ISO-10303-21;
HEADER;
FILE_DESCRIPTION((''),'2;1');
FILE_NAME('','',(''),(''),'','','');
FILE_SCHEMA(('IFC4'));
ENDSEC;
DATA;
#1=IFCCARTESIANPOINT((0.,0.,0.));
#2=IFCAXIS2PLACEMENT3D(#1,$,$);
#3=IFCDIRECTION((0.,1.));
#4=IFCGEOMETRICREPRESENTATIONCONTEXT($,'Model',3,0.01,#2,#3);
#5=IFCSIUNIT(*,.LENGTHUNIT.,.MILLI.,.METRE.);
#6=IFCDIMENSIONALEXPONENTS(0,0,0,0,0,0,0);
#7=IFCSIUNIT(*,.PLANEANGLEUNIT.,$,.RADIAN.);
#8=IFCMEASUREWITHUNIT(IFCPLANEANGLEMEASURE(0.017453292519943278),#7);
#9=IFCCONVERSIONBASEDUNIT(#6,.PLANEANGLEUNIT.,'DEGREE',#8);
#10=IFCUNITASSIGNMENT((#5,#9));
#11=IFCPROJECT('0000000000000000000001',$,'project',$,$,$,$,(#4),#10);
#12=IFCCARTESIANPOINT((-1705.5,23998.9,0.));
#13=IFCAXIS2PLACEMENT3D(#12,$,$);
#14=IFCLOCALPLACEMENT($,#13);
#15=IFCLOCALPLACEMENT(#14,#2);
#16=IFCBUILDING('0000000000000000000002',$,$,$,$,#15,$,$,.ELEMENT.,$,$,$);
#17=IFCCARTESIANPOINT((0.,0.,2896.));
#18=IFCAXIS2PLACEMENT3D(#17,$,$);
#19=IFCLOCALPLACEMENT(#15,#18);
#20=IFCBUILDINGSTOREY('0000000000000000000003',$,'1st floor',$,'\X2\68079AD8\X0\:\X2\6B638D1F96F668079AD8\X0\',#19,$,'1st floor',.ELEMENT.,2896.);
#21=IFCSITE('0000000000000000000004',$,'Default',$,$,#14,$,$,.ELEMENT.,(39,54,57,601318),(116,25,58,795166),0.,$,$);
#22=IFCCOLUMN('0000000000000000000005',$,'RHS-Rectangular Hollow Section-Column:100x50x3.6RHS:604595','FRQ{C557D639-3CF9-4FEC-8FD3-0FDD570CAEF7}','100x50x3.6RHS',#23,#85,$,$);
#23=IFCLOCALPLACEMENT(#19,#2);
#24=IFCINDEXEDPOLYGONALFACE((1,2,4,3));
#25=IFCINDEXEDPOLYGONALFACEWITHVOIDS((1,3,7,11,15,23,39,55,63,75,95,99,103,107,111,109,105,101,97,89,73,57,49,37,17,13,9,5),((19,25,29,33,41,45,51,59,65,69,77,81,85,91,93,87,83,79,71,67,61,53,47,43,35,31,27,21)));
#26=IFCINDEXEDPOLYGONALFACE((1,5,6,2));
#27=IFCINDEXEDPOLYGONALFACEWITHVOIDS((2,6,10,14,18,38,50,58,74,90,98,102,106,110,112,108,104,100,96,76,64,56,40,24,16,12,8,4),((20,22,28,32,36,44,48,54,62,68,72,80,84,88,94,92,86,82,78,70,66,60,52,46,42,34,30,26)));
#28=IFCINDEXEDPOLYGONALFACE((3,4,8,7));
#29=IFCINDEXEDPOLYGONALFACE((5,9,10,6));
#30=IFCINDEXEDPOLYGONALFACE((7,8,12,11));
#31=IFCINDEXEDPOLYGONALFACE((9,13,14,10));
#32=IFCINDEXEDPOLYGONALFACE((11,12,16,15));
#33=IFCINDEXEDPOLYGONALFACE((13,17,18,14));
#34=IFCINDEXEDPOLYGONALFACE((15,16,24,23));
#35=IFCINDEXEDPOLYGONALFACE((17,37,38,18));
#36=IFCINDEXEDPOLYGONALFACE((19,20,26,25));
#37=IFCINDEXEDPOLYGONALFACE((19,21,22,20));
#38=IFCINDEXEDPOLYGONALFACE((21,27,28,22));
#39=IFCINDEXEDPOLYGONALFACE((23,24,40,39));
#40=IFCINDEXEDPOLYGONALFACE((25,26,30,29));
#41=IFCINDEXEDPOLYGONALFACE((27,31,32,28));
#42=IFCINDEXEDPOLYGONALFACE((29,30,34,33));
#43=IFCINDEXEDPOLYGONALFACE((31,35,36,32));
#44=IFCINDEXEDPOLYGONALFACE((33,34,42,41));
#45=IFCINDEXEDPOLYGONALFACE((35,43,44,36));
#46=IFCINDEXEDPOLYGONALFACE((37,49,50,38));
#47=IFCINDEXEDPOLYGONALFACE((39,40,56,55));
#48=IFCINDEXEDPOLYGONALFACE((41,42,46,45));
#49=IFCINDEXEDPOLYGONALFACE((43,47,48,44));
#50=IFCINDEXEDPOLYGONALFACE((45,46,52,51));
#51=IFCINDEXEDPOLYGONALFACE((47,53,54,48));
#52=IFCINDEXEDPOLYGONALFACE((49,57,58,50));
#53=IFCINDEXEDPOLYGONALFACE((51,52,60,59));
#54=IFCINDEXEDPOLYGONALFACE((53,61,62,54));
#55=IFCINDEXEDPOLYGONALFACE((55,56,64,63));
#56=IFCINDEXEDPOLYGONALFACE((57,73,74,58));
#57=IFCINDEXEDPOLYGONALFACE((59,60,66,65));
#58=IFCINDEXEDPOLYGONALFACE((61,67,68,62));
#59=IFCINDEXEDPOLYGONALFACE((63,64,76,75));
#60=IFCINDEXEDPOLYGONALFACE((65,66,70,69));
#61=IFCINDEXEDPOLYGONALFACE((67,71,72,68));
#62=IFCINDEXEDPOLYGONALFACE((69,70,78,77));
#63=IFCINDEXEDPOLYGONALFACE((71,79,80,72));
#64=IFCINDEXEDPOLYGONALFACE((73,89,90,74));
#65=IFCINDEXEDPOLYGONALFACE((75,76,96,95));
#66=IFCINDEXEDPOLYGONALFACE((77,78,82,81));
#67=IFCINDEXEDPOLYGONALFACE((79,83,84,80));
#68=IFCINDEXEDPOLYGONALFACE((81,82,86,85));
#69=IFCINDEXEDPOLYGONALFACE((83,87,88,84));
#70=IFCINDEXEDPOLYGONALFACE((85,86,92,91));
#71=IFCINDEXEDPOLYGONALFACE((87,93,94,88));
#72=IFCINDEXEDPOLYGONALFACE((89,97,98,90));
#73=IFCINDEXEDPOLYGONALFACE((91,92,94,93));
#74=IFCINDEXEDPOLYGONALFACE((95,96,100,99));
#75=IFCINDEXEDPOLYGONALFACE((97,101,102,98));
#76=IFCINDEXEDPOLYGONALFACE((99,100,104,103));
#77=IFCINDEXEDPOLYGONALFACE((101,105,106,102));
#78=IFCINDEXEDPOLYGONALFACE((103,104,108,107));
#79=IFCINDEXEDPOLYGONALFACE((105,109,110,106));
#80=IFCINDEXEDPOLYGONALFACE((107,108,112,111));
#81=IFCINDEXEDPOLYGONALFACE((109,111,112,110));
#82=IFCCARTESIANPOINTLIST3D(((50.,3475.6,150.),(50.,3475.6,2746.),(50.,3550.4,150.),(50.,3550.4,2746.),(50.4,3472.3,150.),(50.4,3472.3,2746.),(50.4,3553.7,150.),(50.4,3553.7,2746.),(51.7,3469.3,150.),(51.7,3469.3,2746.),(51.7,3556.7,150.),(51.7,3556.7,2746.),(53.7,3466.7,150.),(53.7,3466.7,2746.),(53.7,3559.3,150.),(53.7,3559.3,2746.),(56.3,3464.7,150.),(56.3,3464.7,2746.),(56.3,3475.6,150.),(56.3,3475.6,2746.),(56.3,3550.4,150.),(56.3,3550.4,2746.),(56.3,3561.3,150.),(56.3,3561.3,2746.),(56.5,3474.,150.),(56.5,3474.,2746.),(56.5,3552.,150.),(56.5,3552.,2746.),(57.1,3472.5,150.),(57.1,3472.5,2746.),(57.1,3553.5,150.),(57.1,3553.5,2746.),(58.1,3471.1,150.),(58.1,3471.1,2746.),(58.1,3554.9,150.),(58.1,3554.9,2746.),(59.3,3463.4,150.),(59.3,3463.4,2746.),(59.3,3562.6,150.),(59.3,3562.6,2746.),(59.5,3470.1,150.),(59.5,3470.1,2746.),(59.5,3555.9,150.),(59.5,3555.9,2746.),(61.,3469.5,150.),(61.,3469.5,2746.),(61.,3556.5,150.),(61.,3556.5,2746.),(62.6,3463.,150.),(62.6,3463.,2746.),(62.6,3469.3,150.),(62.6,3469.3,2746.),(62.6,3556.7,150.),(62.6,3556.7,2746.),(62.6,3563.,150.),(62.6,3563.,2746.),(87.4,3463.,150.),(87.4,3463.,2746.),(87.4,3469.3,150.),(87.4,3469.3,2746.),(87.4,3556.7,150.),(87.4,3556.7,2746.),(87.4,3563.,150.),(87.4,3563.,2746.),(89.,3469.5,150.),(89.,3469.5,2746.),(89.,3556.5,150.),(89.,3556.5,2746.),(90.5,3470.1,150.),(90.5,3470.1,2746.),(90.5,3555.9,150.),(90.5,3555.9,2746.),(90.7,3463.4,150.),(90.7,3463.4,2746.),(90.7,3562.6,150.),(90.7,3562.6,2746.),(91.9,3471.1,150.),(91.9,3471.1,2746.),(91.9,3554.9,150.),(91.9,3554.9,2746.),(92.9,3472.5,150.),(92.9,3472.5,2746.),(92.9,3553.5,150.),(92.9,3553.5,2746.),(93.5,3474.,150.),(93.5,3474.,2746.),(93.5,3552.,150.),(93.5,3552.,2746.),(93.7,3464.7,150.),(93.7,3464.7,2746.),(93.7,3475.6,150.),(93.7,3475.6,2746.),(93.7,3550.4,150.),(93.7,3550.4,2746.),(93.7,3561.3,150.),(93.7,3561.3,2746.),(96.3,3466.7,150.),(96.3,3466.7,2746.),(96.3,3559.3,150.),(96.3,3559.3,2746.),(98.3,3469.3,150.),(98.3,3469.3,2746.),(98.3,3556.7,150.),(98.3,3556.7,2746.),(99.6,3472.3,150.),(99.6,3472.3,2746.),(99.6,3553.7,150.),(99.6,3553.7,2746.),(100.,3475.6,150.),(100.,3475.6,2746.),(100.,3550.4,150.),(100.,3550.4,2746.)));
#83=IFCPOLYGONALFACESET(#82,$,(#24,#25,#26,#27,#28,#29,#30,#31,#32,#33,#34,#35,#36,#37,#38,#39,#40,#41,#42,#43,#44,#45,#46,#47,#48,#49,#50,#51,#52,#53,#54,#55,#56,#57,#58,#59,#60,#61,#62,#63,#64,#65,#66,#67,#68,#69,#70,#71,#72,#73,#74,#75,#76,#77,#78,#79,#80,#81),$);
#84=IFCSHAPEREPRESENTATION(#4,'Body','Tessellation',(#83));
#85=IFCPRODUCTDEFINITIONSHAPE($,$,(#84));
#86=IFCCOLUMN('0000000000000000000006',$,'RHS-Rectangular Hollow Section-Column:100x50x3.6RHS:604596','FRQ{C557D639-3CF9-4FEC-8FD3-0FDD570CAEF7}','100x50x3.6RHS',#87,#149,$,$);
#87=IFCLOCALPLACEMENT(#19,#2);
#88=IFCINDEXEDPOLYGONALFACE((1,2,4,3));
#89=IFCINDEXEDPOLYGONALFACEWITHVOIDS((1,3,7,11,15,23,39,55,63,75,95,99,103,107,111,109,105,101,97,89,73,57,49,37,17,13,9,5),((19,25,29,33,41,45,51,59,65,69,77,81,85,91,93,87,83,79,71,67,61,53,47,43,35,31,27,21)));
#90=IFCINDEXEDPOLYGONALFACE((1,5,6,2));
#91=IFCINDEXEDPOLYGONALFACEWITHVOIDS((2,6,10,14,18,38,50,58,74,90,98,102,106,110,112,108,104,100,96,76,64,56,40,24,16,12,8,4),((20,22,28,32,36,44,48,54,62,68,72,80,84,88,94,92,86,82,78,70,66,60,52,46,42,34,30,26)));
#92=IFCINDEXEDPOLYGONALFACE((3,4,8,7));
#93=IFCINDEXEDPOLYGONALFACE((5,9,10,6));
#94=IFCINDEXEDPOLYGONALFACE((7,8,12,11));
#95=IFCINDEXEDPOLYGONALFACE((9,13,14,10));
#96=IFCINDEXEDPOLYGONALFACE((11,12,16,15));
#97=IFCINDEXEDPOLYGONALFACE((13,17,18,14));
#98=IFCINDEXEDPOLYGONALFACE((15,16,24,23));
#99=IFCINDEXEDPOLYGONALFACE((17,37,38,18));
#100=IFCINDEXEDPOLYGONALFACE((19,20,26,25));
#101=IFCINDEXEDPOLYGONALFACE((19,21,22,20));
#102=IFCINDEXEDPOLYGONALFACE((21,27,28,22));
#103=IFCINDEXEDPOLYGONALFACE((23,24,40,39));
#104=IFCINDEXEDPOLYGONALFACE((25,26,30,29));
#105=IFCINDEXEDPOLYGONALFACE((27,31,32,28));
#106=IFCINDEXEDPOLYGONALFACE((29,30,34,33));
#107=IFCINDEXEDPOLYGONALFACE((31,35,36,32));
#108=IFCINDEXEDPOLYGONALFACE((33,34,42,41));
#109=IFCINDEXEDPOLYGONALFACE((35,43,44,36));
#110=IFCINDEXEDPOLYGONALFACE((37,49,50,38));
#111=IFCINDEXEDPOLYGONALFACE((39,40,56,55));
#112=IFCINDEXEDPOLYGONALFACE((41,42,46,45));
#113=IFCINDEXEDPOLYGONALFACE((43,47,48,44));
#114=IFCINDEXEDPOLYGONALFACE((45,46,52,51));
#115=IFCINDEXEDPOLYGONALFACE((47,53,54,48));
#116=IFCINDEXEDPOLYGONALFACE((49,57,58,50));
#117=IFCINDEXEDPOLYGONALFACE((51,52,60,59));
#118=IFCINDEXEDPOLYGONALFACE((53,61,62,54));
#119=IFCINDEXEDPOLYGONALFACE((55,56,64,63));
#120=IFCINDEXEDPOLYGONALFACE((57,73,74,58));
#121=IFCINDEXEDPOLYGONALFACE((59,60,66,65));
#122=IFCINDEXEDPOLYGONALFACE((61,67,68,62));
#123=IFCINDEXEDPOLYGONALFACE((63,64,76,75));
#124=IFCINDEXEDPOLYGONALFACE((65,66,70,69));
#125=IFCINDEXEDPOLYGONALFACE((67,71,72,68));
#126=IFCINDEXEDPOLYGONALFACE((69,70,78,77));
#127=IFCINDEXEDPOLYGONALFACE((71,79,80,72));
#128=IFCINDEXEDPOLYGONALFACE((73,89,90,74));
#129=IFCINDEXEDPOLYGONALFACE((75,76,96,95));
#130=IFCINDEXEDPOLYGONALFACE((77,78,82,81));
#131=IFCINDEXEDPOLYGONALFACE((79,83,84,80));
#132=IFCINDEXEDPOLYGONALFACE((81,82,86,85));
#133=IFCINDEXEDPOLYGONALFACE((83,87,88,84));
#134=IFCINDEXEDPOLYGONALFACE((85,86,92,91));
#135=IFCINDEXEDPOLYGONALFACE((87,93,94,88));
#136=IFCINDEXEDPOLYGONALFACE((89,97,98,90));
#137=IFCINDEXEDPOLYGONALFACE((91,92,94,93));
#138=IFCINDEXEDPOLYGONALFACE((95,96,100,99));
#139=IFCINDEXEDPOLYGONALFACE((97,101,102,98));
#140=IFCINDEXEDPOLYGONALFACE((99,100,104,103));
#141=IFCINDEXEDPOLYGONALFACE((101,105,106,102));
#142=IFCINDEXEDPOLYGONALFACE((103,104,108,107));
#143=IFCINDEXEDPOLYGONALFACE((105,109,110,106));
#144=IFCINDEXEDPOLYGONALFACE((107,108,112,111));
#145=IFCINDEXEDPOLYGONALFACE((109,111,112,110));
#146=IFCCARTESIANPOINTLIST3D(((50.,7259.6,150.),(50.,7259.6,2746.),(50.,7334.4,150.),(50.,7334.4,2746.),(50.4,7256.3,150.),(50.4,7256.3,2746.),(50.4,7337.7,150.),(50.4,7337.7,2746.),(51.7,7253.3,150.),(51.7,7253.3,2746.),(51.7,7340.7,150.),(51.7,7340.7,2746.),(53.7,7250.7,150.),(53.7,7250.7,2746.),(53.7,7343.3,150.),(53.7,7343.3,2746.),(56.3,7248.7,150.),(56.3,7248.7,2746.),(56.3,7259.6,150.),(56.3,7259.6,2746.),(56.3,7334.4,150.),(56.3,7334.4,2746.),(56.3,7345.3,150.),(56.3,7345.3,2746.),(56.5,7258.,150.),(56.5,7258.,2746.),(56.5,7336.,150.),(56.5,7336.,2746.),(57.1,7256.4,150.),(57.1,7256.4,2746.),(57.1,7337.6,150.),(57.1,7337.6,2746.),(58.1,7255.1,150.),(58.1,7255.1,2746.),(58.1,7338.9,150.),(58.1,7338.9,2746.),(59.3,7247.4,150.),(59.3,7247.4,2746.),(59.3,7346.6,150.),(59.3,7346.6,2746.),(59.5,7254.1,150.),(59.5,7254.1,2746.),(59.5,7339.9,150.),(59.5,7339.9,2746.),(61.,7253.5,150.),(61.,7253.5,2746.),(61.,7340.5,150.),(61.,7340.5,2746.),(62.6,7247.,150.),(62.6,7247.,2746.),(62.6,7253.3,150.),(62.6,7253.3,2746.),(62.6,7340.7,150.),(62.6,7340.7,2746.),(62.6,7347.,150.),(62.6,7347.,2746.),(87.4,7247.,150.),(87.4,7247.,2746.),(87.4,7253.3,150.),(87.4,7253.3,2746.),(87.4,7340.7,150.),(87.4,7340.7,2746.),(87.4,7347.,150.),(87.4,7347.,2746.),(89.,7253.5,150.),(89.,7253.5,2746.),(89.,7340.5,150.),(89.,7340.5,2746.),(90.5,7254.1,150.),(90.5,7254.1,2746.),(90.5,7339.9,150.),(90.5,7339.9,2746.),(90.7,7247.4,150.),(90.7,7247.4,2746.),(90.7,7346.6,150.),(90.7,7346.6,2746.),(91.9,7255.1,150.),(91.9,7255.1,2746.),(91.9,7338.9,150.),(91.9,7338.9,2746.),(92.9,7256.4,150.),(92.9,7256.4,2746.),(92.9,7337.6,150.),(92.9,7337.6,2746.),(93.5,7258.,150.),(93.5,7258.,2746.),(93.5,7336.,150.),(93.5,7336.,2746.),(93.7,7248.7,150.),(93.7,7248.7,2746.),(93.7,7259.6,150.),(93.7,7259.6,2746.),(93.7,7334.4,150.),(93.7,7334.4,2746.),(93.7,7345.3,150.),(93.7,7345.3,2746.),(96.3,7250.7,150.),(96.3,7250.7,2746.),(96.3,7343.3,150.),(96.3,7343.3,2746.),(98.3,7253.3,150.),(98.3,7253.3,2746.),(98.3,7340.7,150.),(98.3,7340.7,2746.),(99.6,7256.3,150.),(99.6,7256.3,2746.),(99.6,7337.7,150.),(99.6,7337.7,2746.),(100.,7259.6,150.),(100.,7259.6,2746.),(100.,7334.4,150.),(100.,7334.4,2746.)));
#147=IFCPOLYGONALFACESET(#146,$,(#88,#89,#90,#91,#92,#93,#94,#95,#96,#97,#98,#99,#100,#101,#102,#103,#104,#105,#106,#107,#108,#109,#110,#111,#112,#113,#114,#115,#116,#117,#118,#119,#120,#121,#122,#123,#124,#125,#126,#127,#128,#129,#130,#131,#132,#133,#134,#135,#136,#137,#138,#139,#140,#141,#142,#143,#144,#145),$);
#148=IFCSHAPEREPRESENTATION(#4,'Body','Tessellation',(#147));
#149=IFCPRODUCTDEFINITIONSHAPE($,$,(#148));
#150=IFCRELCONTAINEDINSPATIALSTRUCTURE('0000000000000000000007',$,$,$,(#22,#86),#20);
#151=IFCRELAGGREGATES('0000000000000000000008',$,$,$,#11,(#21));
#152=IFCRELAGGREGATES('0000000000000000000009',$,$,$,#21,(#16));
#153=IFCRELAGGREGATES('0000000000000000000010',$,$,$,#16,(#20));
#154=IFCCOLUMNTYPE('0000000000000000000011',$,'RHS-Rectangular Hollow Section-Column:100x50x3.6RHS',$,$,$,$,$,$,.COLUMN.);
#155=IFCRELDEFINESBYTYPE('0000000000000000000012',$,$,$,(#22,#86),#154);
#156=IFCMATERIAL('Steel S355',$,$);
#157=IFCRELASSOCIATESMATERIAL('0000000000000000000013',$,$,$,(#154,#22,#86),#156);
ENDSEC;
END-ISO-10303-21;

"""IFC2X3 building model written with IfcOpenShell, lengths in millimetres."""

from ifc_helpers import new_model, entity, si_unit, converted_unit, direction, frame, origin, origin_2d, place, context, project, spatial, hollow_rectangle, extrude, clip, halfspace, material, type_object, element, save


model = new_model("IFC2X3")

# Units and contexts
model_context = context("Model", 3, precision=0.01, world=origin(), true_north=direction((0.0, 1.0)))
ifc_project = project(units=[si_unit("LENGTHUNIT", "METRE", prefix="MILLI"), converted_unit("PLANEANGLEUNIT", "DEGREE", entity("IfcPlaneAngleMeasure", 0.017453292519943278), si_unit("PLANEANGLEUNIT", "RADIAN"), dimensions=[0, 0, 0, 0, 0, 0, 0])], contexts=[model_context])

# Site, building, storey
site_placement = place(None, frame((-1705.5, 23998.9, 0.0)))
site = spatial("IfcSite", under=ifc_project, at=site_placement, Name="Default", CompositionType="ELEMENT", RefLatitude=(39, 54, 57, 601318), RefLongitude=(116, 25, 58, 795166), RefElevation=0.0)
building_placement = place(site_placement, origin())
building = spatial("IfcBuilding", under=site, at=building_placement, CompositionType="ELEMENT")
storey_placement = place(building_placement, frame((0.0, 0.0, 2896.0)))
storey = spatial("IfcBuildingStorey", under=building, at=storey_placement, Name="1st floor", ObjectType="标高:正负零标高", LongName="1st floor", CompositionType="ELEMENT", Elevation=2896.0)

# Columns
ifc_material_1 = material(Name="Steel S355")
column_type_1 = type_object("IfcColumnType", Name="RHS-Rectangular Hollow Section-Column:100x50x3.6RHS", PredefinedType="COLUMN", material=ifc_material_1)
column_1_placement = place(storey_placement, frame((75.0, 3513.0, 2746.0), z_axis=(0.0, 0.0, 1.0), x_axis=(-1.0, 0.0, 0.0)))
element("IfcColumn", 1, at=column_1_placement, inside=storey, type_object=column_type_1, material=ifc_material_1, Name="RHS-Rectangular Hollow Section-Column:100x50x3.6RHS:604595", Description="FRQ{C557D639-3CF9-4FEC-8FD3-0FDD570CAEF7}", ObjectType="100x50x3.6RHS", context=model_context, shape_type="Clipping", body=[
    clip(extrude(hollow_rectangle(XDim=50.0, YDim=100.0, WallThickness=6.3, InnerFilletRadius=6.3, OuterFilletRadius=12.6, at=origin_2d()), origin(), (0.0, 0.0, -1.0), 2651.9), halfspace(frame((75.0, 3513.0, -2596.0), z_axis=(0.0, 0.0, 1.0), x_axis=(-1.0, 0.0, 0.0)), True)),
])
column_2_placement = place(storey_placement, frame((75.0, 7297.0, 2746.0), z_axis=(0.0, 0.0, 1.0), x_axis=(-1.0, 0.0, 0.0)))
element("IfcColumn", 2, at=column_2_placement, inside=storey, type_object=column_type_1, material=ifc_material_1, Name="RHS-Rectangular Hollow Section-Column:100x50x3.6RHS:604596", Description="FRQ{C557D639-3CF9-4FEC-8FD3-0FDD570CAEF7}", ObjectType="100x50x3.6RHS", context=model_context, shape_type="Clipping", body=[
    clip(extrude(hollow_rectangle(XDim=50.0, YDim=100.0, WallThickness=6.3, InnerFilletRadius=6.3, OuterFilletRadius=12.6, at=origin_2d()), origin(), (0.0, 0.0, -1.0), 2651.9), halfspace(frame((75.0, 7297.0, -2596.0), z_axis=(0.0, 0.0, 1.0), x_axis=(-1.0, 0.0, 0.0)), True)),
])

save(model, "model.ifc")
